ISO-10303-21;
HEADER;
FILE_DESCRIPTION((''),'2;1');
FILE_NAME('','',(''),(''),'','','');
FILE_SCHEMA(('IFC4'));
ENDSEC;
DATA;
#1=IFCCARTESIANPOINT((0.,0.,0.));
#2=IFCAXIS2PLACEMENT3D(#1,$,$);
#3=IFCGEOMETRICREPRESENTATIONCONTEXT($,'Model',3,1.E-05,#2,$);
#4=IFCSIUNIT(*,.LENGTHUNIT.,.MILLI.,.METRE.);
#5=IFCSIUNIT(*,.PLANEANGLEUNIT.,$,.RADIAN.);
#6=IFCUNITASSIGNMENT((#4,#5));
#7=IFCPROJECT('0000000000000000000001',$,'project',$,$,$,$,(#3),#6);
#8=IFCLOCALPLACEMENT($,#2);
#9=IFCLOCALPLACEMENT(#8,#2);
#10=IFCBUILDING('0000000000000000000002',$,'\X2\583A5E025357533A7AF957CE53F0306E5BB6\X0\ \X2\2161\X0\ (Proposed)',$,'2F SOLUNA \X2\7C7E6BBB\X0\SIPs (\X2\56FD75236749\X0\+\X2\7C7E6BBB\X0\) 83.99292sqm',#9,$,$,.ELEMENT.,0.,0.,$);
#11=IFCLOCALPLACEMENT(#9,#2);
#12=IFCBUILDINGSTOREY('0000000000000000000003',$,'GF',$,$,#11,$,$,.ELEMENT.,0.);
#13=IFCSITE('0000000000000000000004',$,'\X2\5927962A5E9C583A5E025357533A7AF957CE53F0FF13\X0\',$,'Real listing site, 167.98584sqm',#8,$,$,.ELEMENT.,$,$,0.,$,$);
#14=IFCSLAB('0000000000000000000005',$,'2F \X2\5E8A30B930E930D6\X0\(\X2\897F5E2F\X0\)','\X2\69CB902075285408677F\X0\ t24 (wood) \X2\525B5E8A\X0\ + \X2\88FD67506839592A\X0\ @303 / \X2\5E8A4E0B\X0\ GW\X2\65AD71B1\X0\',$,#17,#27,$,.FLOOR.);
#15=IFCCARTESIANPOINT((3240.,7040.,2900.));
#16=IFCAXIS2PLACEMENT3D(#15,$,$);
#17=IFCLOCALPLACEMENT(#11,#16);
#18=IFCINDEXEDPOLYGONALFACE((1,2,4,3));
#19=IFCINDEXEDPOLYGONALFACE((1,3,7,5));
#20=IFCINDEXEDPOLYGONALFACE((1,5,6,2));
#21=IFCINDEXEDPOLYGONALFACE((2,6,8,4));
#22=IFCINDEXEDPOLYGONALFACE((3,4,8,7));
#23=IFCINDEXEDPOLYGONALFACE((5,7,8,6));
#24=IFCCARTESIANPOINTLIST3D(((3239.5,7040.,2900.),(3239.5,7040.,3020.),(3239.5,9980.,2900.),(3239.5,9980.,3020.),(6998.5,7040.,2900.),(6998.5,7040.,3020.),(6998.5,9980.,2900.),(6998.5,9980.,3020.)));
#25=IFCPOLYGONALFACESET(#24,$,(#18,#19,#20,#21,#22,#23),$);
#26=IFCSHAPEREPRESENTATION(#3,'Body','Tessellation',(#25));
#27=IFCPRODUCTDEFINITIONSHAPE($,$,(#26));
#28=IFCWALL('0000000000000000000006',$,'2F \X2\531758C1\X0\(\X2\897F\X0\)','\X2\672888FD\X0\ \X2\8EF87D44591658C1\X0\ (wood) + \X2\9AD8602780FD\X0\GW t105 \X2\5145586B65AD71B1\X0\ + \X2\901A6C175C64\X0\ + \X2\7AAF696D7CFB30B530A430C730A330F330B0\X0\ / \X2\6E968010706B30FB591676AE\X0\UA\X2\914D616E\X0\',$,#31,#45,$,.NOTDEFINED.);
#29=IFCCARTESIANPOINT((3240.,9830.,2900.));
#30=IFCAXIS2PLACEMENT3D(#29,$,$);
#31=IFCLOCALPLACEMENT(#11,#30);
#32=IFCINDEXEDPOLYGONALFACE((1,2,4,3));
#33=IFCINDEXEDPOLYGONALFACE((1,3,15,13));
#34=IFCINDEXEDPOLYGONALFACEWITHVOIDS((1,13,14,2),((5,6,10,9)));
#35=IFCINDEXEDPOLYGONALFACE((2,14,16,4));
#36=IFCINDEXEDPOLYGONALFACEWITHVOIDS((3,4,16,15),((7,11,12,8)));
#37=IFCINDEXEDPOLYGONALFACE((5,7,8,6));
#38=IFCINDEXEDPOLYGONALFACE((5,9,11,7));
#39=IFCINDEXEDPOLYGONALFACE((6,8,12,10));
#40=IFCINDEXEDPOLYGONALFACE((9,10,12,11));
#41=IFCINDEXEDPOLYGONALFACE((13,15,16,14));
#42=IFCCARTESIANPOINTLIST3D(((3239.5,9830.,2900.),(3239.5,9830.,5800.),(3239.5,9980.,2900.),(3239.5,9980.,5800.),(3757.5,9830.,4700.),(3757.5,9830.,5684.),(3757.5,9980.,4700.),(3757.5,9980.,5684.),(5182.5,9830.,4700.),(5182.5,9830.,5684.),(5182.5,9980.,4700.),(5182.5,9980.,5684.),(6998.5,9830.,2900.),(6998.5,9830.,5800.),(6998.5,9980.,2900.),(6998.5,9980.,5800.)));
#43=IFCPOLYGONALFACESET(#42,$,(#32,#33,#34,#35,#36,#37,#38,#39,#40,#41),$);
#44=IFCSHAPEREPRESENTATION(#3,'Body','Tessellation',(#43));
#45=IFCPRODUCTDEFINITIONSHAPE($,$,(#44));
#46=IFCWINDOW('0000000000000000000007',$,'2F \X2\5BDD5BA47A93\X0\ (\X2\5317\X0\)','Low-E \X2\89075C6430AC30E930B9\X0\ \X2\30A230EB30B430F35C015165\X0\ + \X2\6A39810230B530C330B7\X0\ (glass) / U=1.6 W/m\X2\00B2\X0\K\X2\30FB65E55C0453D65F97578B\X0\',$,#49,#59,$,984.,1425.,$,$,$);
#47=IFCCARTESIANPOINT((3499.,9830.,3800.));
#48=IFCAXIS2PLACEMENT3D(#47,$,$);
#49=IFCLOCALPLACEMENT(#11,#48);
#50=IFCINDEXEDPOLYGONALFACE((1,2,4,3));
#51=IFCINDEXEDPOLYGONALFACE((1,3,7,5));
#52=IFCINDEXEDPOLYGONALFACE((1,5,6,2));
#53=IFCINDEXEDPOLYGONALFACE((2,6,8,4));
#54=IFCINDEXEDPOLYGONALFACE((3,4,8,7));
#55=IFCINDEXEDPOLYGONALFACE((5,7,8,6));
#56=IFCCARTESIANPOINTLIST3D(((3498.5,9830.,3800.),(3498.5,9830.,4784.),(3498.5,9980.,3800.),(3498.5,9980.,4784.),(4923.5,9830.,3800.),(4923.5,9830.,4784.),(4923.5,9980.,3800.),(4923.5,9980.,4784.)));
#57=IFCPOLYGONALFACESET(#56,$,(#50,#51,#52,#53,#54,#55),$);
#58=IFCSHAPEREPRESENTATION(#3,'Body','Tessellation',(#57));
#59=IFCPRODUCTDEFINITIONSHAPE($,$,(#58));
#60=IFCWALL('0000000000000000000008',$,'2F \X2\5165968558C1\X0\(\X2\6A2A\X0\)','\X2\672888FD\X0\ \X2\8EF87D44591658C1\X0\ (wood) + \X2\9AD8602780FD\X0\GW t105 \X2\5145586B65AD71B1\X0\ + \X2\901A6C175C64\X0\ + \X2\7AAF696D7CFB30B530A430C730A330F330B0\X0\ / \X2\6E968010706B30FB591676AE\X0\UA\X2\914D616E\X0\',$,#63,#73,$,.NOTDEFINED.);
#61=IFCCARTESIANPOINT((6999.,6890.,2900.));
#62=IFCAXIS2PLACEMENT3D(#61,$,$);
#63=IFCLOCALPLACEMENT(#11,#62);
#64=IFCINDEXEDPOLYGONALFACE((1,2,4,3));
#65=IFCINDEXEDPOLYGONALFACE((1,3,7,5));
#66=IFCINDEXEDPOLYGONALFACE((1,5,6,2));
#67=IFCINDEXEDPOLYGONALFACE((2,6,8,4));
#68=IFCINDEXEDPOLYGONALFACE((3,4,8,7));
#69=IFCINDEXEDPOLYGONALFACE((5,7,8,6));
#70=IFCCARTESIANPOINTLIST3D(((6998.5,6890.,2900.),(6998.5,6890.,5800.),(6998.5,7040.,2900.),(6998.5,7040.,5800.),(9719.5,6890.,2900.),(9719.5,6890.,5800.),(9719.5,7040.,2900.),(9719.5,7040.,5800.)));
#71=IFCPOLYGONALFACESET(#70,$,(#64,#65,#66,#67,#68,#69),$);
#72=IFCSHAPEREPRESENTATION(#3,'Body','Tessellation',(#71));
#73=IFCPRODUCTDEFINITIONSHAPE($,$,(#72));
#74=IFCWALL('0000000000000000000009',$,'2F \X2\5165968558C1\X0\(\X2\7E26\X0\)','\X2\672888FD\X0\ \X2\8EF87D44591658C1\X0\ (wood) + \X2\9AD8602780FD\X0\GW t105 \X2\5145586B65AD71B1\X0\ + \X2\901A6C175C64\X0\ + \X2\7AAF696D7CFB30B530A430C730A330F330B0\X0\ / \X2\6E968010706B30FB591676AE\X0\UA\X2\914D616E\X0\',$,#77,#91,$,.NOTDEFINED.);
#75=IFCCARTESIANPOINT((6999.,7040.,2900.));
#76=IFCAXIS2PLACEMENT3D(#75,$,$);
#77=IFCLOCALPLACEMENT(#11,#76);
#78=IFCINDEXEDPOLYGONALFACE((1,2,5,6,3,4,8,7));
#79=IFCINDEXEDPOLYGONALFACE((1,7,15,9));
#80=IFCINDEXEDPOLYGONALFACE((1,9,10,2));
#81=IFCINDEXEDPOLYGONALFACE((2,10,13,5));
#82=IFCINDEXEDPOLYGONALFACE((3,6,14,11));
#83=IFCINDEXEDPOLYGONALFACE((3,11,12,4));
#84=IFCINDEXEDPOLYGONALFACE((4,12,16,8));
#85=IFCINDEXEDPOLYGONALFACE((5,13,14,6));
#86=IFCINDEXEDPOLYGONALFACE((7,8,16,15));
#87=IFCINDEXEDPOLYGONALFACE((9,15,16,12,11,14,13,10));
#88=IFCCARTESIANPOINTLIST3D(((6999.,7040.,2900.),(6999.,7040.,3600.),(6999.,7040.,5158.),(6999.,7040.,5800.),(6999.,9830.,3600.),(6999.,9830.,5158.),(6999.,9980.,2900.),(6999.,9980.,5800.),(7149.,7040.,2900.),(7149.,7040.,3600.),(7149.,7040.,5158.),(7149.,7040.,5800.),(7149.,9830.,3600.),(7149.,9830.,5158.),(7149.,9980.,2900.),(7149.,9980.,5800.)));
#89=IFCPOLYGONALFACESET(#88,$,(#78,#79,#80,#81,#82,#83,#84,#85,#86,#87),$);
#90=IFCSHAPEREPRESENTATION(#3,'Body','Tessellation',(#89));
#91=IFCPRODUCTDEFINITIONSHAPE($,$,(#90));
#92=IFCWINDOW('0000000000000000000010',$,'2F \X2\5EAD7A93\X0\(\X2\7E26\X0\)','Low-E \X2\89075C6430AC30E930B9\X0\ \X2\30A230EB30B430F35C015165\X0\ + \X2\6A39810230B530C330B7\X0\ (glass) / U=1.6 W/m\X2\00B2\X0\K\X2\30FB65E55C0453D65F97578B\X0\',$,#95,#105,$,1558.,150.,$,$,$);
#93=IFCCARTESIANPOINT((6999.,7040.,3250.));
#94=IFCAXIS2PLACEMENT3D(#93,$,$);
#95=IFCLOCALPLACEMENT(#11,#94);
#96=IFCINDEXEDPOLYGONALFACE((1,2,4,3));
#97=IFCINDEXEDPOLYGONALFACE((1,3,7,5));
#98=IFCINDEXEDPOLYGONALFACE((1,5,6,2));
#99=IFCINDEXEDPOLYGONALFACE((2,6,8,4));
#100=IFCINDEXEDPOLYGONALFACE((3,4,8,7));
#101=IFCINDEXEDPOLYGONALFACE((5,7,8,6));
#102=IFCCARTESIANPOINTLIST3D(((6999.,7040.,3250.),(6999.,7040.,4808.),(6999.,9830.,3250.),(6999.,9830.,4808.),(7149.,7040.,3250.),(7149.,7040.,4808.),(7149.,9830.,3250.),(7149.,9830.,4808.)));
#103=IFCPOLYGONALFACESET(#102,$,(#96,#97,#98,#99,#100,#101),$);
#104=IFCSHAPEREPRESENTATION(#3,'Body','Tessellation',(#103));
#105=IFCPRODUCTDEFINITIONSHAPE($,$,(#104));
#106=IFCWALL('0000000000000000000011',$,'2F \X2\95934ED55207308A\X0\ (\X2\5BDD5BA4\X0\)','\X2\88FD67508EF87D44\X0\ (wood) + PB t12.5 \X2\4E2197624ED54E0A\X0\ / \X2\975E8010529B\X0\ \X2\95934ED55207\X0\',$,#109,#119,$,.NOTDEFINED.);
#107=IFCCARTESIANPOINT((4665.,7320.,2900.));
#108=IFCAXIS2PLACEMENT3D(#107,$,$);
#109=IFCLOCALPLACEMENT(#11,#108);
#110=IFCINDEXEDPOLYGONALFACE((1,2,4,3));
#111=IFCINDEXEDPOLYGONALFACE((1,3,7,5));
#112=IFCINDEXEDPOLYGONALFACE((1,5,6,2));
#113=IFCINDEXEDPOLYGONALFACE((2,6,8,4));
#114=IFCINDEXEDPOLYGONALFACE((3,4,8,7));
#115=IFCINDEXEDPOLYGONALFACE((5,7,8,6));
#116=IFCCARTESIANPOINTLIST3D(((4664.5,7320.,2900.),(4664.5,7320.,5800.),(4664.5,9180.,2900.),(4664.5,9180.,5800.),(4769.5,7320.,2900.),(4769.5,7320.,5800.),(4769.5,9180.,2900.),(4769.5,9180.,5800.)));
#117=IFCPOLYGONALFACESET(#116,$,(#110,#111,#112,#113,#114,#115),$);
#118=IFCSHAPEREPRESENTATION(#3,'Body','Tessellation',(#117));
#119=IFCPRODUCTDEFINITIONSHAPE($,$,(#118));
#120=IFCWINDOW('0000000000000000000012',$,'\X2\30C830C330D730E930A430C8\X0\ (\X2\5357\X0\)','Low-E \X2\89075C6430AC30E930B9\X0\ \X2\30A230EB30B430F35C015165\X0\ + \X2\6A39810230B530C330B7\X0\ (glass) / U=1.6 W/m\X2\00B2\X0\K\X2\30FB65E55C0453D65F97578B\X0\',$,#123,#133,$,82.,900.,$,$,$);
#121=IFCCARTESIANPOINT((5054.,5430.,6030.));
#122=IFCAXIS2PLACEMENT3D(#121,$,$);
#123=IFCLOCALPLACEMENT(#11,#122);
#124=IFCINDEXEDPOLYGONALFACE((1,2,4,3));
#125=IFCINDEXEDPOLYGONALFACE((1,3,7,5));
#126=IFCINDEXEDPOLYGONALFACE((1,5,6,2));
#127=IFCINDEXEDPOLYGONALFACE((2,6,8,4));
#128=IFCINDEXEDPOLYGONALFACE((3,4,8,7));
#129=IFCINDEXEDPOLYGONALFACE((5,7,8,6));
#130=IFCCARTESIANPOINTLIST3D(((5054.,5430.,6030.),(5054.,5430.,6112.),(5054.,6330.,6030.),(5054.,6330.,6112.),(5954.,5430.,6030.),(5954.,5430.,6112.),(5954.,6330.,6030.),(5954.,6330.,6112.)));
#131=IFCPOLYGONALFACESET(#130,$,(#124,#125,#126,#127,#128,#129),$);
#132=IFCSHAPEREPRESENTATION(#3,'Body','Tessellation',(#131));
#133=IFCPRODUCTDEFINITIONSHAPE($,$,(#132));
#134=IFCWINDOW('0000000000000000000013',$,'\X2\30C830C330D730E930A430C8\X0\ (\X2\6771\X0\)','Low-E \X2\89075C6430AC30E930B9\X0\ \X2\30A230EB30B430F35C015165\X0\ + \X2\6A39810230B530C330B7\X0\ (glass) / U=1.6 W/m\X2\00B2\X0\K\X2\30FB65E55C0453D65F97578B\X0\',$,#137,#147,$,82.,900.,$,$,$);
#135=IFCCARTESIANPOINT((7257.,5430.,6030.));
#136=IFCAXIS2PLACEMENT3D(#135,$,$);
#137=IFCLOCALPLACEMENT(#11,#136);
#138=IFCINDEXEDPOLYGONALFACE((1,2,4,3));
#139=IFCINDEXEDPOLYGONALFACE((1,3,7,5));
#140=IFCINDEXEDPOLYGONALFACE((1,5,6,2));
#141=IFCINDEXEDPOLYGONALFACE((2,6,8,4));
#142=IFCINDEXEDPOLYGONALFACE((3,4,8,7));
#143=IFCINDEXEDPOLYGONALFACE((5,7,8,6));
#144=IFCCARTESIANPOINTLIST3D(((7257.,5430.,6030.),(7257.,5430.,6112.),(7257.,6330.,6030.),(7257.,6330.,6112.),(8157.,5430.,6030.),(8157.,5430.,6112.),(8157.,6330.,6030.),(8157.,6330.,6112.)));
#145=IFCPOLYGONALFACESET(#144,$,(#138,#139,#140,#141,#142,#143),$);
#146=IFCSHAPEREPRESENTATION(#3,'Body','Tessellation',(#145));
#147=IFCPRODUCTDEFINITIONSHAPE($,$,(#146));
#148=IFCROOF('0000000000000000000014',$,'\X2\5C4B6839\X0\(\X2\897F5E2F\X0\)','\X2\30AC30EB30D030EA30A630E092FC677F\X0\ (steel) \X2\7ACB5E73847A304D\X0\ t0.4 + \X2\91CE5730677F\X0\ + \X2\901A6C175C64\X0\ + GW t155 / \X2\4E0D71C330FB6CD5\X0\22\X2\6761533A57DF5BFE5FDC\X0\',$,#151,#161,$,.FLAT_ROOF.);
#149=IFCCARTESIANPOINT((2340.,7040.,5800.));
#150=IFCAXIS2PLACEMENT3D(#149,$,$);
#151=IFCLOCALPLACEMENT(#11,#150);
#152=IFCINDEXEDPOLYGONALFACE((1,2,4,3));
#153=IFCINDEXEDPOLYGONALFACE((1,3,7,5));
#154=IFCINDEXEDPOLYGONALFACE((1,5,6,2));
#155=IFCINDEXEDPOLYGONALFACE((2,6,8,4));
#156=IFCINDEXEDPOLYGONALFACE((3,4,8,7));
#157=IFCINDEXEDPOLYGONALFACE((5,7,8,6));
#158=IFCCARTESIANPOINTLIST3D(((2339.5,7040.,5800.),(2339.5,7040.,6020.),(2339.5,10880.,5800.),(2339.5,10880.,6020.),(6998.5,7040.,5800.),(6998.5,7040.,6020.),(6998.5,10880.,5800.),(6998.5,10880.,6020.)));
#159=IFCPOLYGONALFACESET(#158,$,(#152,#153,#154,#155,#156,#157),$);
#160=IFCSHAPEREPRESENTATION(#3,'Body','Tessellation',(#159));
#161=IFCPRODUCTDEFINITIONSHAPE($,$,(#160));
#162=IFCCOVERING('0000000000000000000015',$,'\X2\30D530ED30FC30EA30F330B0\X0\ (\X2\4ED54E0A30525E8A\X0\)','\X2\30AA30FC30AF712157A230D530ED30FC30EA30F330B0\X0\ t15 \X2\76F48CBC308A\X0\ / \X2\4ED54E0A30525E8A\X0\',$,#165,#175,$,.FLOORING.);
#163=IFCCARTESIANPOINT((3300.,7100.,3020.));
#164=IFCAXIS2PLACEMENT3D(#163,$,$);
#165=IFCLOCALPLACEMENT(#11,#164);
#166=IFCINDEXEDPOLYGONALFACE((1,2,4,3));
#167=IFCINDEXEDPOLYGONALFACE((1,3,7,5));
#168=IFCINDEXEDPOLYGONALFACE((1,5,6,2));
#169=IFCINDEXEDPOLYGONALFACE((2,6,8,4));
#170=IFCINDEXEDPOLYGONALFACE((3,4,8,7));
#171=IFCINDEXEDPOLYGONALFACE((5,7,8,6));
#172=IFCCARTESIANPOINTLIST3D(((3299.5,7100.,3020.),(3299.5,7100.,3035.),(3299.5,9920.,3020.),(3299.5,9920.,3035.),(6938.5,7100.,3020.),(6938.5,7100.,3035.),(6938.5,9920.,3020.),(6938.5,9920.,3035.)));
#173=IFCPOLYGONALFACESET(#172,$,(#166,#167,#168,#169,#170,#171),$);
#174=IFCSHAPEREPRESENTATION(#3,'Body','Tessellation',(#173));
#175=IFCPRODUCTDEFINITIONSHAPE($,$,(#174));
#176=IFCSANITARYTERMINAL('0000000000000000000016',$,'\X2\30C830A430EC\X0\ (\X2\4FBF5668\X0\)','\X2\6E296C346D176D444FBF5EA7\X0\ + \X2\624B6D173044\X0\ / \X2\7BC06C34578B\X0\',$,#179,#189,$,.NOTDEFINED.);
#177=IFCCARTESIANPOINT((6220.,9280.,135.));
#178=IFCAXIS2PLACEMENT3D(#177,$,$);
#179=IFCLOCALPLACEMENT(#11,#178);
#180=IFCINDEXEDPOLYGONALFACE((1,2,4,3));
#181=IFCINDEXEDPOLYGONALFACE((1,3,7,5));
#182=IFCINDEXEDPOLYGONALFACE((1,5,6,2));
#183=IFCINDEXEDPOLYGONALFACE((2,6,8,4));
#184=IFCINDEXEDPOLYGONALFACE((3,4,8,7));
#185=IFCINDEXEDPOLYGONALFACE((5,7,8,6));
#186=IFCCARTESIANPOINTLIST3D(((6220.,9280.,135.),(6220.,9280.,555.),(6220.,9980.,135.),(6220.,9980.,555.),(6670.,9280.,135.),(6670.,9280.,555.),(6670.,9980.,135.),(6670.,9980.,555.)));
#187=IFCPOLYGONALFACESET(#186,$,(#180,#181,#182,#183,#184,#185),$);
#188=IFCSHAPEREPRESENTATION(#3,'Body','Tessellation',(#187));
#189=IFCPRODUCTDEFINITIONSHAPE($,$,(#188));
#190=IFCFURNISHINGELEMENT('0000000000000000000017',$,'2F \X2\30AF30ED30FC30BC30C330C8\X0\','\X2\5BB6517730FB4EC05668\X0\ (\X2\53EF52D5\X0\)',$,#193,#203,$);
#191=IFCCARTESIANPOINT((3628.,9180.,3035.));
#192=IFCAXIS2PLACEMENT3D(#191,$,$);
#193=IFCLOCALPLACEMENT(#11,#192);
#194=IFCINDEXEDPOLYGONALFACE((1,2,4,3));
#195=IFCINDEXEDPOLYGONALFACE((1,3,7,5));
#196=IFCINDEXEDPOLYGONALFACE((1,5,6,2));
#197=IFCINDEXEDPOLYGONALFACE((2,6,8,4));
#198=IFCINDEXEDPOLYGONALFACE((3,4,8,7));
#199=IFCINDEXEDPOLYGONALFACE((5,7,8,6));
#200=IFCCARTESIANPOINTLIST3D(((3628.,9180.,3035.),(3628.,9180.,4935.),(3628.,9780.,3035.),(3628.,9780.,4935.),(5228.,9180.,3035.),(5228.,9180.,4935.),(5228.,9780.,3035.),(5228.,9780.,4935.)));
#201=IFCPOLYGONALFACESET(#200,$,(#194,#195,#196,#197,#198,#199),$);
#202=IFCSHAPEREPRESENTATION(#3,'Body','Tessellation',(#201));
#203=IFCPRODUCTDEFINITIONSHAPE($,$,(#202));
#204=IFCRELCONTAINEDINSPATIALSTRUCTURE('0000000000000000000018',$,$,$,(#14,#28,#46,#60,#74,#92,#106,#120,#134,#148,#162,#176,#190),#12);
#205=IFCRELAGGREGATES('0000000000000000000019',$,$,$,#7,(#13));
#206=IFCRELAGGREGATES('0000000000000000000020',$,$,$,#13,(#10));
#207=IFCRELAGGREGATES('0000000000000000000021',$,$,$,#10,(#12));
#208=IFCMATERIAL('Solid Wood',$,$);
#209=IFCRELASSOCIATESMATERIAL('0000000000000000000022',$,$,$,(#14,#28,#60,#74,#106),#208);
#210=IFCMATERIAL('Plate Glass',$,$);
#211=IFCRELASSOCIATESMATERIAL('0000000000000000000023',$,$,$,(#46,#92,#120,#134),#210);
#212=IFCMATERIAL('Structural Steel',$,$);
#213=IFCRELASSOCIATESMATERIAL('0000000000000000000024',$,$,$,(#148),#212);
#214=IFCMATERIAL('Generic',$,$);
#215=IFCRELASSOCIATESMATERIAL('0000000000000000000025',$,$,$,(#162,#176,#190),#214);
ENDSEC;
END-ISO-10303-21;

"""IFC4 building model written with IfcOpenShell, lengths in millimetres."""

from ifc_helpers import new_model, si_unit, frame, frame_2d, origin, place, context, project, spatial, rectangle, extrude, material, element, fill, save


model = new_model("IFC4")

# Units and contexts
model_context = context("Model", 3, precision=1e-05, world=origin())
ifc_project = project(units=[si_unit("LENGTHUNIT", "METRE", prefix="MILLI"), si_unit("PLANEANGLEUNIT", "RADIAN")], contexts=[model_context])

# Site, building, storey
site_placement = place(None, origin())
site = spatial("IfcSite", under=ifc_project, at=site_placement, Name="大阪府堺市南区竹城台３", ObjectType="Real listing site, 167.98584sqm", CompositionType="ELEMENT", RefElevation=0.0)
building_placement = place(site_placement, origin())
building = spatial("IfcBuilding", under=site, at=building_placement, Name="堺市南区竹城台の家 Ⅱ (Proposed)", ObjectType="2F SOLUNA 籾殻SIPs (国産杉+籾殻) 83.99292sqm", CompositionType="ELEMENT", ElevationOfRefHeight=0.0, ElevationOfTerrain=0.0)
storey_placement = place(building_placement, origin())
storey = spatial("IfcBuildingStorey", under=building, at=storey_placement, Name="GF", CompositionType="ELEMENT", Elevation=0.0)

# Slab
ifc_material_1 = material(Name="Solid Wood")
slab_placement = place(storey_placement, frame((3240.0, 7040.0, 2900.0)))
element("IfcSlab", 1, at=slab_placement, inside=storey, material=ifc_material_1, Name="2F 床スラブ(西帯)", Description="構造用合板 t24 (wood) 剛床 + 製材根太 @303 / 床下 GW断熱", PredefinedType="FLOOR", context=model_context, shape_type="SweptSolid", body=[
    extrude(rectangle(XDim=3759.0, YDim=2940.0, at=frame_2d((1879.0, 1470.0))), frame((3240.0, 7040.0, 2900.0)), (0.0, 0.0, 1.0), 120.0),
])

# Wall, opening, window
wall_1_placement = place(storey_placement, frame((3240.0, 9830.0, 2900.0)))
wall_1 = element("IfcWall", 2, at=wall_1_placement, inside=storey, material=ifc_material_1, Name="2F 北壁(西)", Description="木製 軸組外壁 (wood) + 高性能GW t105 充填断熱 + 通気層 + 窯業系サイディング / 準耐火・外皮UA配慮", PredefinedType="NOTDEFINED", context=model_context, shape_type="SweptSolid", body=[
    extrude(rectangle(XDim=3759.0, YDim=150.0, at=frame_2d((1879.0, 75.0))), frame((3240.0, 9830.0, 2900.0)), (0.0, 0.0, 1.0), 2900.0),
])
opening_1_placement = place(storey_placement, frame((3499.0, 9830.0, 3800.0)))
opening_1 = element("IfcOpeningElement", 3, at=opening_1_placement, cuts=wall_1, PredefinedType="NOTDEFINED", context=model_context, shape_type="SweptSolid", body=[
    extrude(rectangle(XDim=1425.0, YDim=150.0, at=frame_2d((712.0, 75.0))), frame((3499.0, 9830.0, 3800.0)), (0.0, 0.0, 1.0), 984.0),
])
ifc_material_2 = material(Name="Plate Glass")
window_1_placement = place(storey_placement, frame((3499.0, 9830.0, 3800.0)))
window_1 = element("IfcWindow", 4, at=window_1_placement, inside=storey, material=ifc_material_2, Name="2F 寝室窓 (北)", Description="Low-E 複層ガラス アルゴン封入 + 樹脂サッシ (glass) / U=1.6 W/m²K・日射取得型", OverallHeight=984.0, OverallWidth=1425.0, context=model_context, shape_type="SweptSolid", body=[
    extrude(rectangle(XDim=1425.0, YDim=150.0, at=frame_2d((712.0, 75.0))), frame((3499.0, 9830.0, 3800.0)), (0.0, 0.0, 1.0), 984.0),
])
fill(opening_1, window_1)

# Wall
wall_2_placement = place(storey_placement, frame((6999.0, 6890.0, 2900.0)))
element("IfcWall", 5, at=wall_2_placement, inside=storey, material=ifc_material_1, Name="2F 入隅壁(横)", Description="木製 軸組外壁 (wood) + 高性能GW t105 充填断熱 + 通気層 + 窯業系サイディング / 準耐火・外皮UA配慮", PredefinedType="NOTDEFINED", context=model_context, shape_type="SweptSolid", body=[
    extrude(rectangle(XDim=2721.0, YDim=150.0, at=frame_2d((1360.0, 75.0))), frame((6999.0, 6890.0, 2900.0)), (0.0, 0.0, 1.0), 2900.0),
])

# Wall, opening, window
wall_3_placement = place(storey_placement, frame((6999.0, 7040.0, 2900.0)))
wall_3 = element("IfcWall", 6, at=wall_3_placement, inside=storey, material=ifc_material_1, Name="2F 入隅壁(縦)", Description="木製 軸組外壁 (wood) + 高性能GW t105 充填断熱 + 通気層 + 窯業系サイディング / 準耐火・外皮UA配慮", PredefinedType="NOTDEFINED", context=model_context, shape_type="SweptSolid", body=[
    extrude(rectangle(XDim=150.0, YDim=2940.0, at=frame_2d((75.0, 1470.0))), frame((6999.0, 7040.0, 2900.0)), (0.0, 0.0, 1.0), 2900.0),
])
opening_2_placement = place(storey_placement, frame((6999.0, 7040.0, 3250.0)))
opening_2 = element("IfcOpeningElement", 7, at=opening_2_placement, cuts=wall_3, PredefinedType="NOTDEFINED", context=model_context, shape_type="SweptSolid", body=[
    extrude(rectangle(XDim=150.0, YDim=2790.0, at=frame_2d((75.0, 1395.0))), frame((6999.0, 7040.0, 3250.0)), (0.0, 0.0, 1.0), 1558.0),
])
window_2_placement = place(storey_placement, frame((6999.0, 7040.0, 3250.0)))
window_2 = element("IfcWindow", 8, at=window_2_placement, inside=storey, material=ifc_material_2, Name="2F 庭窓(縦)", Description="Low-E 複層ガラス アルゴン封入 + 樹脂サッシ (glass) / U=1.6 W/m²K・日射取得型", OverallHeight=1558.0, OverallWidth=150.0, context=model_context, shape_type="SweptSolid", body=[
    extrude(rectangle(XDim=150.0, YDim=2790.0, at=frame_2d((75.0, 1395.0))), frame((6999.0, 7040.0, 3250.0)), (0.0, 0.0, 1.0), 1558.0),
])
fill(opening_2, window_2)

# Wall
wall_4_placement = place(storey_placement, frame((4665.0, 7320.0, 2900.0)))
element("IfcWall", 9, at=wall_4_placement, inside=storey, material=ifc_material_1, Name="2F 間仕切り (寝室)", Description="製材軸組 (wood) + PB t12.5 両面仕上 / 非耐力 間仕切", PredefinedType="NOTDEFINED", context=model_context, shape_type="SweptSolid", body=[
    extrude(rectangle(XDim=105.0, YDim=1860.0, at=frame_2d((52.0, 930.0))), frame((4665.0, 7320.0, 2900.0)), (0.0, 0.0, 1.0), 2900.0),
])

# Windows
window_3_placement = place(storey_placement, frame((5054.0, 5430.0, 6030.0)))
element("IfcWindow", 10, at=window_3_placement, inside=storey, material=ifc_material_2, Name="トップライト (南)", Description="Low-E 複層ガラス アルゴン封入 + 樹脂サッシ (glass) / U=1.6 W/m²K・日射取得型", OverallHeight=82.0, OverallWidth=900.0, context=model_context, shape_type="SweptSolid", body=[
    extrude(rectangle(XDim=900.0, YDim=900.0, at=frame_2d((450.0, 450.0))), frame((5054.0, 5430.0, 6030.0)), (0.0, 0.0, 1.0), 82.0),
])
window_4_placement = place(storey_placement, frame((7257.0, 5430.0, 6030.0)))
element("IfcWindow", 11, at=window_4_placement, inside=storey, material=ifc_material_2, Name="トップライト (東)", Description="Low-E 複層ガラス アルゴン封入 + 樹脂サッシ (glass) / U=1.6 W/m²K・日射取得型", OverallHeight=82.0, OverallWidth=900.0, context=model_context, shape_type="SweptSolid", body=[
    extrude(rectangle(XDim=900.0, YDim=900.0, at=frame_2d((450.0, 450.0))), frame((7257.0, 5430.0, 6030.0)), (0.0, 0.0, 1.0), 82.0),
])

# Roof
ifc_material_3 = material(Name="Structural Steel")
for number, where, name in (
    (12, (2340.0, 7040.0, 5800.0), "屋根(西帯)"),
):
    element("IfcRoof", number, at=place(storey_placement, frame(where)), inside=storey, material=ifc_material_3, Name=name, Description="ガルバリウム鋼板 (steel) 立平葺き t0.4 + 野地板 + 通気層 + GW t155 / 不燃・法22条区域対応", PredefinedType="FLAT_ROOF", context=model_context, shape_type="SweptSolid", body=[
        extrude(rectangle(XDim=4659.0, YDim=3840.0, at=frame_2d((2329.0, 1920.0))), frame((2340.0, 7040.0, 5800.0)), (0.0, 0.0, 1.0), 220.0),
    ])

# Covering
ifc_material_4 = material(Name="Generic")
covering_placement = place(storey_placement, frame((3300.0, 7100.0, 3020.0)))
element("IfcCovering", 13, at=covering_placement, inside=storey, material=ifc_material_4, Name="フローリング (仕上げ床)", Description="オーク無垢フローリング t15 直貼り / 仕上げ床", PredefinedType="FLOORING", context=model_context, shape_type="SweptSolid", body=[
    extrude(rectangle(XDim=3639.0, YDim=2820.0, at=frame_2d((1819.0, 1410.0))), frame((3300.0, 7100.0, 3020.0)), (0.0, 0.0, 1.0), 15.0),
])

# Sanitary terminal
sanitary_terminal_placement = place(storey_placement, frame((6220.0, 9280.0, 135.0)))
element("IfcSanitaryTerminal", 14, at=sanitary_terminal_placement, inside=storey, material=ifc_material_4, Name="トイレ (便器)", Description="温水洗浄便座 + 手洗い / 節水型", PredefinedType="NOTDEFINED", context=model_context, shape_type="SweptSolid", body=[
    extrude(rectangle(XDim=450.0, YDim=700.0, at=frame_2d((225.0, 350.0))), frame((6220.0, 9280.0, 135.0)), (0.0, 0.0, 1.0), 420.0),
])

# Furnishing element
furnishing_1_placement = place(storey_placement, frame((3628.0, 9180.0, 3035.0)))
element("IfcFurnishingElement", 15, at=furnishing_1_placement, inside=storey, material=ifc_material_4, Name="2F クローゼット", Description="家具・什器 (可動)", context=model_context, shape_type="SweptSolid", body=[
    extrude(rectangle(XDim=1600.0, YDim=600.0, at=frame_2d((800.0, 300.0))), frame((3628.0, 9180.0, 3035.0)), (0.0, 0.0, 1.0), 1900.0),
])

save(model, "model.ifc")
